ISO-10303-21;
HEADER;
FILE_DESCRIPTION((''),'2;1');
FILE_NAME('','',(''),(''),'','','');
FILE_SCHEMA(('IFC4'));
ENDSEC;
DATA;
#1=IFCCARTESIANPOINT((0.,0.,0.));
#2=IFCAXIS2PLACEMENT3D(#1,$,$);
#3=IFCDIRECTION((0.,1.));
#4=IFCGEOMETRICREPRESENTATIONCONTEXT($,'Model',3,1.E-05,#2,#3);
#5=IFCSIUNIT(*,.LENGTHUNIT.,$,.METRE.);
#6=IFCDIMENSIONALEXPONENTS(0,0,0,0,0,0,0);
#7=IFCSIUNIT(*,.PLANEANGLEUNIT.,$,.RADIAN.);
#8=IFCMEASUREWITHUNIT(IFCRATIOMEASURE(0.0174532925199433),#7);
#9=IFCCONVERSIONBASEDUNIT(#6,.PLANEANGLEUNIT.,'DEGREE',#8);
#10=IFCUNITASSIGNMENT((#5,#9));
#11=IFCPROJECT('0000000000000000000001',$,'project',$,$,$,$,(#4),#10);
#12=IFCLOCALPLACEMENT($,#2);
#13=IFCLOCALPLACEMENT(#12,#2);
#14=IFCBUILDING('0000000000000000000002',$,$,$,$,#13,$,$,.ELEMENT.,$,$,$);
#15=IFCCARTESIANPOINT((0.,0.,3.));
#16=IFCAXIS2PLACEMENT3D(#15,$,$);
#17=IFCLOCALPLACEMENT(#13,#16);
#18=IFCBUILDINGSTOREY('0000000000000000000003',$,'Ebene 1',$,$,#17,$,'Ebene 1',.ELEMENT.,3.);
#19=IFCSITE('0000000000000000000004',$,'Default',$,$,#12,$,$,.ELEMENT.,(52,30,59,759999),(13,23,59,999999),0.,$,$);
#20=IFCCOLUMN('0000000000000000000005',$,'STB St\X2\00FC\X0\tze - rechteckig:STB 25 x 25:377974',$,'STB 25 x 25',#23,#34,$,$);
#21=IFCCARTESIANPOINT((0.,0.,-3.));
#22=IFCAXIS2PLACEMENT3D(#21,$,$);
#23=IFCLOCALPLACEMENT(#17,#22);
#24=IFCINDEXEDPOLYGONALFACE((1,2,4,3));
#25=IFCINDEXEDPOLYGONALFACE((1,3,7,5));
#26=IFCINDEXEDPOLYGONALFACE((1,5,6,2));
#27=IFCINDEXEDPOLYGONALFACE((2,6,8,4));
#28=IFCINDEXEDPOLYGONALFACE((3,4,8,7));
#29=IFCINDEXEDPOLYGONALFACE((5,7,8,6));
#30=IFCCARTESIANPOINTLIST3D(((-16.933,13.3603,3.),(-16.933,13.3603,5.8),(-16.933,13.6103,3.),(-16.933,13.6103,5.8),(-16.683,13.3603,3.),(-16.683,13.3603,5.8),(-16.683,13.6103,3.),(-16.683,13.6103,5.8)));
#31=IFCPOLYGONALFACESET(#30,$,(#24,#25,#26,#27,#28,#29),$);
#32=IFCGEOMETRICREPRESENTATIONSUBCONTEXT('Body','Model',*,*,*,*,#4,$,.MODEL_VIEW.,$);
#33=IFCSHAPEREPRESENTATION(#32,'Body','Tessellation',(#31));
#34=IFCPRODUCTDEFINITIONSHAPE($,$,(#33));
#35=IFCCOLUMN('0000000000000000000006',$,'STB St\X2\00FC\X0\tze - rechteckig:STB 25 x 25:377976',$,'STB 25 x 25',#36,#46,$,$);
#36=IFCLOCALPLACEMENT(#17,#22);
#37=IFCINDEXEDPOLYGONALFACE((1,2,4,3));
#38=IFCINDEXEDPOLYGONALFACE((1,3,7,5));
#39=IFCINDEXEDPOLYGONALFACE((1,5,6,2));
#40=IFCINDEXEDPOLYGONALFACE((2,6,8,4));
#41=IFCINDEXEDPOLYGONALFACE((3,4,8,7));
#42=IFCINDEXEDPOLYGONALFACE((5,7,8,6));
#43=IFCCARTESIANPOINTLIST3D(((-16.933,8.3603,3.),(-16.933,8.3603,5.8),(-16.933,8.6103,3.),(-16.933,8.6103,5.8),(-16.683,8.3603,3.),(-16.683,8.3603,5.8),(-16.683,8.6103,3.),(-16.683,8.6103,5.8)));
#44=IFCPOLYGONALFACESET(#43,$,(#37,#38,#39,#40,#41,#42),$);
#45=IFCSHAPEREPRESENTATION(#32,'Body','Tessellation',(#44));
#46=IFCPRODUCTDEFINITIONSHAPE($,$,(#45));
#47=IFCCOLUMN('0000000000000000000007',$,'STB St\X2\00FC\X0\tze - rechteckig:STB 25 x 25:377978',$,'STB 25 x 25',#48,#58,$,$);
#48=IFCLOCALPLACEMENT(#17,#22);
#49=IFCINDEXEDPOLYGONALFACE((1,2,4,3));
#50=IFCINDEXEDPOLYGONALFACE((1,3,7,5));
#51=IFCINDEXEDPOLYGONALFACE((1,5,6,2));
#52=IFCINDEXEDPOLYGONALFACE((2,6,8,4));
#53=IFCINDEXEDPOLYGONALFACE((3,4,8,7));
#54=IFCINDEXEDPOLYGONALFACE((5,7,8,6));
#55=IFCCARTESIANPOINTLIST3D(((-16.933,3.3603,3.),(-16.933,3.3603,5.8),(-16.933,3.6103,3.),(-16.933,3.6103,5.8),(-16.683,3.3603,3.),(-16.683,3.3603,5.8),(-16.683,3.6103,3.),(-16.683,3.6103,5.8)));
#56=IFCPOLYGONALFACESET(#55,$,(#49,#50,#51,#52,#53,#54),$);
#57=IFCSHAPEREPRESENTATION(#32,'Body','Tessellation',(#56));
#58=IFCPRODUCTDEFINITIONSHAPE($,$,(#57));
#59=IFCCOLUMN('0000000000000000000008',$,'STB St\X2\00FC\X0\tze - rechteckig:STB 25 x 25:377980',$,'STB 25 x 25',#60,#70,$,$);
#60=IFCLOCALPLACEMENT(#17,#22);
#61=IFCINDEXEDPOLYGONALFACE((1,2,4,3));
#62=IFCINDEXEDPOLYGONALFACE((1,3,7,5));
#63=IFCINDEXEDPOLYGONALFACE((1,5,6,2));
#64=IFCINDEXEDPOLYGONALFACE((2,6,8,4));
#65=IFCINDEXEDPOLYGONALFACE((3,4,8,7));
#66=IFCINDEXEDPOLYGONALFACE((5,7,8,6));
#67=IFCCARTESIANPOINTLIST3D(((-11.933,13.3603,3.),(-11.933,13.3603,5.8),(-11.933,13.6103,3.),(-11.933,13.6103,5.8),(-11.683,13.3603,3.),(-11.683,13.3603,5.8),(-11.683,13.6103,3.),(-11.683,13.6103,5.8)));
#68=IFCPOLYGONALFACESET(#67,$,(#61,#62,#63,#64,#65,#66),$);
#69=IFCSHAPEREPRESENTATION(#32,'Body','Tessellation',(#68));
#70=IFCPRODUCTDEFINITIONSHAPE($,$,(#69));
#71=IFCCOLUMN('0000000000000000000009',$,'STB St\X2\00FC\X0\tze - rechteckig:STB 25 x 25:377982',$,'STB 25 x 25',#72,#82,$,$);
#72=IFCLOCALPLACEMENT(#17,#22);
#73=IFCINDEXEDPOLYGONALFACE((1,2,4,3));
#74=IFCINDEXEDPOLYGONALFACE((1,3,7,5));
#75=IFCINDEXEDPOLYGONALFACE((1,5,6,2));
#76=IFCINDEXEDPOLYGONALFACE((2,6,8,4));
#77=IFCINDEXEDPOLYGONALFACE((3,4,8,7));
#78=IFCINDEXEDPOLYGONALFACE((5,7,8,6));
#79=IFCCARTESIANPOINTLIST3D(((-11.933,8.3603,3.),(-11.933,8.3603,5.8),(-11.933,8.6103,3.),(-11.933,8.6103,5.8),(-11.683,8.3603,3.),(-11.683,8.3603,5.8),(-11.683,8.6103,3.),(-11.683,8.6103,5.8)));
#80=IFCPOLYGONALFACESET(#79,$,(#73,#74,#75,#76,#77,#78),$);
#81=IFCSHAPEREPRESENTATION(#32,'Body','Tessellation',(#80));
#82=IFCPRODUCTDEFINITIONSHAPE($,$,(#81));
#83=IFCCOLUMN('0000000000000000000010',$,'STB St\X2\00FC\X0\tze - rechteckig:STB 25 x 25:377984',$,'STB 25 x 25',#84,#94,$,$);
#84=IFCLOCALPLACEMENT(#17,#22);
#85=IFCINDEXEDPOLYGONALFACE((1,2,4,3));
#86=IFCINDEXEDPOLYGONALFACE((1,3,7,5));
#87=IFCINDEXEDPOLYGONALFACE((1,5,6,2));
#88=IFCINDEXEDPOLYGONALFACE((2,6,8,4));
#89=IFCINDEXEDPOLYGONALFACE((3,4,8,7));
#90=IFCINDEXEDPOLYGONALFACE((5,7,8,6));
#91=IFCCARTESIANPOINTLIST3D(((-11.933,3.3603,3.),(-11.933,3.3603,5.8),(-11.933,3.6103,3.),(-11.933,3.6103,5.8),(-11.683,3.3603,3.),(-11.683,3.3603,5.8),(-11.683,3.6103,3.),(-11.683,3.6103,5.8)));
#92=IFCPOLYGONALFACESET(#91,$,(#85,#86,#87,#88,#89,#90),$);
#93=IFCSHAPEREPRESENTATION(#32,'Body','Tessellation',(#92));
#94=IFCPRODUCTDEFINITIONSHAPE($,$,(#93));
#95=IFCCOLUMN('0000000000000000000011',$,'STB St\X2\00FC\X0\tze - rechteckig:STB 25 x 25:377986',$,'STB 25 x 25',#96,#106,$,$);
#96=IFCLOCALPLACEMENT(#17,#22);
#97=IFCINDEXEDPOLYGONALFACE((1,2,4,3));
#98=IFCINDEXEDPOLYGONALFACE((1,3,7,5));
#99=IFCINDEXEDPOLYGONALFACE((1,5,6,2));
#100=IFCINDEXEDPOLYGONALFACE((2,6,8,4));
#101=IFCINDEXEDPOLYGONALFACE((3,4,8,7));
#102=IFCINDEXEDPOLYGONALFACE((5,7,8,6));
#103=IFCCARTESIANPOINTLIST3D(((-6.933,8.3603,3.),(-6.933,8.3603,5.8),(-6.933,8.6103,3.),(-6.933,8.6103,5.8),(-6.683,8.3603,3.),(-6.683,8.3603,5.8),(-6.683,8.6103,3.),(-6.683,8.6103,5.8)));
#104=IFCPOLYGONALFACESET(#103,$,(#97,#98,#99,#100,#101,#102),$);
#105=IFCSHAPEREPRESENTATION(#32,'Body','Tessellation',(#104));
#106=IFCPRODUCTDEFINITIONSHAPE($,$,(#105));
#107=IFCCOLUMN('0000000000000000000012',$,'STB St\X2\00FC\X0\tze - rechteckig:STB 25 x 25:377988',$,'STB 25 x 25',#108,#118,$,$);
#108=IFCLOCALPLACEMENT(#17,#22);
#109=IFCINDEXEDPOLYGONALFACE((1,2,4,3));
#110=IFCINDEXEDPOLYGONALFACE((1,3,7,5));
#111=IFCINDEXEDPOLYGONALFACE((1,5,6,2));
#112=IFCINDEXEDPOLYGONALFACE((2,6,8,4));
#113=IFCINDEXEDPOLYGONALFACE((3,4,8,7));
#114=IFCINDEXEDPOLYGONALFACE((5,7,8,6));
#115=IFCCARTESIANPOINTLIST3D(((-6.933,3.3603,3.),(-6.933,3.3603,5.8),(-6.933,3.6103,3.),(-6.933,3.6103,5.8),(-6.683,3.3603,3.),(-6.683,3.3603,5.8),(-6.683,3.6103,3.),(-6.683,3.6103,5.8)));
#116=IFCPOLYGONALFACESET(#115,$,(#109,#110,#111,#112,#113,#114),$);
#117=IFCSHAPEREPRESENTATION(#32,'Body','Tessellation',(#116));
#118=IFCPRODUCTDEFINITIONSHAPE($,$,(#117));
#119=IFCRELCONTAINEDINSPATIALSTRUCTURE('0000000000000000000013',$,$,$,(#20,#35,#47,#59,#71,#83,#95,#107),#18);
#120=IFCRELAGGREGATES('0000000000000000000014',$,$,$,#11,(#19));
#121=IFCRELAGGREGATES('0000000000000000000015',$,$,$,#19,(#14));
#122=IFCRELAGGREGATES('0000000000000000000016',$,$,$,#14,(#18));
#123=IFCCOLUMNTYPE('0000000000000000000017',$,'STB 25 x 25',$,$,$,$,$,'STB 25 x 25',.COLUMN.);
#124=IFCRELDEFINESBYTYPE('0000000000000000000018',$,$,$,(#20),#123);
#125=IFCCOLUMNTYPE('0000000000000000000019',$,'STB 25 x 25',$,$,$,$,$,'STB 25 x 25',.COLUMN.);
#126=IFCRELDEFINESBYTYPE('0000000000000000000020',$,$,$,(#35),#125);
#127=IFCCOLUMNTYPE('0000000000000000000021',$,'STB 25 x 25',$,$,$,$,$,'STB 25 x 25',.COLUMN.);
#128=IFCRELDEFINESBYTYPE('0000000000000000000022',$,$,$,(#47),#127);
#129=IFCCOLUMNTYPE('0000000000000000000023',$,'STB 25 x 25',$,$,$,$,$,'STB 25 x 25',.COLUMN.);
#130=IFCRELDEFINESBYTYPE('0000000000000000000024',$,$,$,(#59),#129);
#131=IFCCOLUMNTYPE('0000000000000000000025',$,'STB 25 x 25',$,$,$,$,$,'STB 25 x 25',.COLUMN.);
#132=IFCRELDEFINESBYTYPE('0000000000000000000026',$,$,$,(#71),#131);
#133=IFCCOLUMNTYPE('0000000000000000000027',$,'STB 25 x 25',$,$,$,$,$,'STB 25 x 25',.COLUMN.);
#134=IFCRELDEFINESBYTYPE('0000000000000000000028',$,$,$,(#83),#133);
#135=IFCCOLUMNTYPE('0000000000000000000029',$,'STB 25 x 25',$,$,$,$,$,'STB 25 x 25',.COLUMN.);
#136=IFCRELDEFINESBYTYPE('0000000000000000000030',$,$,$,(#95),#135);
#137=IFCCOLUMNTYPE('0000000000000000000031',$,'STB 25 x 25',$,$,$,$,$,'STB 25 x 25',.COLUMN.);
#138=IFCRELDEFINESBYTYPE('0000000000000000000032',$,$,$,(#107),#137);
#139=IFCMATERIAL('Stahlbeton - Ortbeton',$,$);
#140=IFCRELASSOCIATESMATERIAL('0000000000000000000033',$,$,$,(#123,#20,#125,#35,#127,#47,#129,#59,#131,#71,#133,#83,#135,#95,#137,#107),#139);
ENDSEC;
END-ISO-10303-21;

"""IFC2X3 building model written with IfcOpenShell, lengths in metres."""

from ifc_helpers import new_model, entity, si_unit, converted_unit, direction, frame, frame_2d, origin, origin_2d_with_axis, place, context, subcontext, project, spatial, rectangle, extrude, source, transform, mapped, material, type_object, type_shapes, element, save


model = new_model("IFC2X3")

# Units and contexts
model_context = context("Model", 3, precision=1e-05, world=origin(), true_north=direction((0.0, 1.0)))
body_context = subcontext(model_context, "Body", "Model", "MODEL_VIEW")
ifc_project = project(units=[si_unit("LENGTHUNIT", "METRE"), converted_unit("PLANEANGLEUNIT", "DEGREE", entity("IfcRatioMeasure", 0.0174532925199433), si_unit("PLANEANGLEUNIT", "RADIAN"), dimensions=[0, 0, 0, 0, 0, 0, 0])], contexts=[model_context])

# Site, building, storey
site_placement = place(None, origin())
site = spatial("IfcSite", under=ifc_project, at=site_placement, Name="Default", CompositionType="ELEMENT", RefLatitude=(52, 30, 59, 759999), RefLongitude=(13, 23, 59, 999999), RefElevation=0.0)
building_placement = place(site_placement, origin())
building = spatial("IfcBuilding", under=site, at=building_placement, CompositionType="ELEMENT")
storey_placement = place(building_placement, frame((0.0, 0.0, 3.0)))
storey = spatial("IfcBuildingStorey", under=building, at=storey_placement, Name="Ebene 1", LongName="Ebene 1", CompositionType="ELEMENT", Elevation=3.0)

# Columns
ifc_material_1 = material(Name="Stahlbeton - Ortbeton")
column_type_1 = type_object("IfcColumnType", Name="STB 25 x 25", ElementType="STB 25 x 25", PredefinedType="COLUMN", material=ifc_material_1)
shared_shape_1 = source(origin(), body_context, "Body", "SweptSolid", [
    extrude(rectangle(XDim=0.25, YDim=0.25, at=origin_2d_with_axis()), frame((-16.808, 13.4853, 3.0), z_axis=(0.0, 0.0, 1.0), x_axis=(0.0, -1.0, 0.0)), (0.0, 0.0, 1.0), 2.8),
])
type_shapes(column_type_1, [shared_shape_1])
column_1_placement = place(storey_placement, frame((0.0, 0.0, -3.0)))
element("IfcColumn", 1, at=column_1_placement, inside=storey, type_object=column_type_1, material=ifc_material_1, Name="STB Stütze - rechteckig:STB 25 x 25:377974", ObjectType="STB 25 x 25", context=body_context, shape_type="MappedRepresentation", body=[
    mapped(shared_shape_1, transform((0.0, 0.0, 0.0), scale=1.0)),
])
column_type_2 = type_object("IfcColumnType", Name="STB 25 x 25", ElementType="STB 25 x 25", PredefinedType="COLUMN", material=ifc_material_1)
shared_shape_2 = source(origin(), body_context, "Body", "SweptSolid", [
    extrude(rectangle(XDim=0.25, YDim=0.25, at=origin_2d_with_axis()), frame((-16.808, 8.4853, 3.0), z_axis=(0.0, 0.0, 1.0), x_axis=(0.0, -1.0, 0.0)), (0.0, 0.0, 1.0), 2.8),
])
type_shapes(column_type_2, [shared_shape_2])
column_2_placement = place(storey_placement, frame((0.0, 0.0, -3.0)))
element("IfcColumn", 2, at=column_2_placement, inside=storey, type_object=column_type_2, material=ifc_material_1, Name="STB Stütze - rechteckig:STB 25 x 25:377976", ObjectType="STB 25 x 25", context=body_context, shape_type="MappedRepresentation", body=[
    mapped(shared_shape_2, transform((0.0, 0.0, 0.0), scale=1.0)),
])
column_type_3 = type_object("IfcColumnType", Name="STB 25 x 25", ElementType="STB 25 x 25", PredefinedType="COLUMN", material=ifc_material_1)
shared_shape_3 = source(origin(), body_context, "Body", "SweptSolid", [
    extrude(rectangle(XDim=0.25, YDim=0.25, at=frame_2d((0.0, 0.0), x_axis=(1.0, 0.0))), frame((-16.808, 3.4853, 3.0), z_axis=(0.0, 0.0, 1.0), x_axis=(0.0, -1.0, 0.0)), (0.0, 0.0, 1.0), 2.8),
])
type_shapes(column_type_3, [shared_shape_3])
column_3_placement = place(storey_placement, frame((0.0, 0.0, -3.0)))
element("IfcColumn", 3, at=column_3_placement, inside=storey, type_object=column_type_3, material=ifc_material_1, Name="STB Stütze - rechteckig:STB 25 x 25:377978", ObjectType="STB 25 x 25", context=body_context, shape_type="MappedRepresentation", body=[
    mapped(shared_shape_3, transform((0.0, 0.0, 0.0), scale=1.0)),
])
column_type_4 = type_object("IfcColumnType", Name="STB 25 x 25", ElementType="STB 25 x 25", PredefinedType="COLUMN", material=ifc_material_1)
shared_shape_4 = source(origin(), body_context, "Body", "SweptSolid", [
    extrude(rectangle(XDim=0.25, YDim=0.25, at=origin_2d_with_axis()), frame((-11.808, 13.4853, 3.0), z_axis=(0.0, 0.0, 1.0), x_axis=(0.0, -1.0, 0.0)), (0.0, 0.0, 1.0), 2.8),
])
type_shapes(column_type_4, [shared_shape_4])
column_4_placement = place(storey_placement, frame((0.0, 0.0, -3.0)))
element("IfcColumn", 4, at=column_4_placement, inside=storey, type_object=column_type_4, material=ifc_material_1, Name="STB Stütze - rechteckig:STB 25 x 25:377980", ObjectType="STB 25 x 25", context=body_context, shape_type="MappedRepresentation", body=[
    mapped(shared_shape_4, transform((0.0, 0.0, 0.0), scale=1.0)),
])
column_type_5 = type_object("IfcColumnType", Name="STB 25 x 25", ElementType="STB 25 x 25", PredefinedType="COLUMN", material=ifc_material_1)
shared_shape_5 = source(origin(), body_context, "Body", "SweptSolid", [
    extrude(rectangle(XDim=0.25, YDim=0.25, at=origin_2d_with_axis()), frame((-11.808, 8.4853, 3.0), z_axis=(0.0, 0.0, 1.0), x_axis=(0.0, -1.0, 0.0)), (0.0, 0.0, 1.0), 2.8),
])
type_shapes(column_type_5, [shared_shape_5])
column_5_placement = place(storey_placement, frame((0.0, 0.0, -3.0)))
element("IfcColumn", 5, at=column_5_placement, inside=storey, type_object=column_type_5, material=ifc_material_1, Name="STB Stütze - rechteckig:STB 25 x 25:377982", ObjectType="STB 25 x 25", context=body_context, shape_type="MappedRepresentation", body=[
    mapped(shared_shape_5, transform((0.0, 0.0, 0.0), scale=1.0)),
])
column_type_6 = type_object("IfcColumnType", Name="STB 25 x 25", ElementType="STB 25 x 25", PredefinedType="COLUMN", material=ifc_material_1)
shared_shape_6 = source(origin(), body_context, "Body", "SweptSolid", [
    extrude(rectangle(XDim=0.25, YDim=0.25, at=frame_2d((0.0, 0.0), x_axis=(1.0, 0.0))), frame((-11.808, 3.4853, 3.0), z_axis=(0.0, 0.0, 1.0), x_axis=(0.0, -1.0, 0.0)), (0.0, 0.0, 1.0), 2.8),
])
type_shapes(column_type_6, [shared_shape_6])
column_6_placement = place(storey_placement, frame((0.0, 0.0, -3.0)))
element("IfcColumn", 6, at=column_6_placement, inside=storey, type_object=column_type_6, material=ifc_material_1, Name="STB Stütze - rechteckig:STB 25 x 25:377984", ObjectType="STB 25 x 25", context=body_context, shape_type="MappedRepresentation", body=[
    mapped(shared_shape_6, transform((0.0, 0.0, 0.0), scale=1.0)),
])
column_type_7 = type_object("IfcColumnType", Name="STB 25 x 25", ElementType="STB 25 x 25", PredefinedType="COLUMN", material=ifc_material_1)
shared_shape_7 = source(origin(), body_context, "Body", "SweptSolid", [
    extrude(rectangle(XDim=0.25, YDim=0.25, at=origin_2d_with_axis()), frame((-6.808, 8.4853, 3.0), z_axis=(0.0, 0.0, 1.0), x_axis=(0.0, -1.0, 0.0)), (0.0, 0.0, 1.0), 2.8),
])
type_shapes(column_type_7, [shared_shape_7])
column_7_placement = place(storey_placement, frame((0.0, 0.0, -3.0)))
element("IfcColumn", 7, at=column_7_placement, inside=storey, type_object=column_type_7, material=ifc_material_1, Name="STB Stütze - rechteckig:STB 25 x 25:377986", ObjectType="STB 25 x 25", context=body_context, shape_type="MappedRepresentation", body=[
    mapped(shared_shape_7, transform((0.0, 0.0, 0.0), scale=1.0)),
])
column_type_8 = type_object("IfcColumnType", Name="STB 25 x 25", ElementType="STB 25 x 25", PredefinedType="COLUMN", material=ifc_material_1)
shared_shape_8 = source(origin(), body_context, "Body", "SweptSolid", [
    extrude(rectangle(XDim=0.25, YDim=0.25, at=frame_2d((0.0, 0.0), x_axis=(1.0, 0.0))), frame((-6.808, 3.4853, 3.0), z_axis=(0.0, 0.0, 1.0), x_axis=(0.0, -1.0, 0.0)), (0.0, 0.0, 1.0), 2.8),
])
type_shapes(column_type_8, [shared_shape_8])
column_8_placement = place(storey_placement, frame((0.0, 0.0, -3.0)))
element("IfcColumn", 8, at=column_8_placement, inside=storey, type_object=column_type_8, material=ifc_material_1, Name="STB Stütze - rechteckig:STB 25 x 25:377988", ObjectType="STB 25 x 25", context=body_context, shape_type="MappedRepresentation", body=[
    mapped(shared_shape_8, transform((0.0, 0.0, 0.0), scale=1.0)),
])

save(model, "model.ifc")
